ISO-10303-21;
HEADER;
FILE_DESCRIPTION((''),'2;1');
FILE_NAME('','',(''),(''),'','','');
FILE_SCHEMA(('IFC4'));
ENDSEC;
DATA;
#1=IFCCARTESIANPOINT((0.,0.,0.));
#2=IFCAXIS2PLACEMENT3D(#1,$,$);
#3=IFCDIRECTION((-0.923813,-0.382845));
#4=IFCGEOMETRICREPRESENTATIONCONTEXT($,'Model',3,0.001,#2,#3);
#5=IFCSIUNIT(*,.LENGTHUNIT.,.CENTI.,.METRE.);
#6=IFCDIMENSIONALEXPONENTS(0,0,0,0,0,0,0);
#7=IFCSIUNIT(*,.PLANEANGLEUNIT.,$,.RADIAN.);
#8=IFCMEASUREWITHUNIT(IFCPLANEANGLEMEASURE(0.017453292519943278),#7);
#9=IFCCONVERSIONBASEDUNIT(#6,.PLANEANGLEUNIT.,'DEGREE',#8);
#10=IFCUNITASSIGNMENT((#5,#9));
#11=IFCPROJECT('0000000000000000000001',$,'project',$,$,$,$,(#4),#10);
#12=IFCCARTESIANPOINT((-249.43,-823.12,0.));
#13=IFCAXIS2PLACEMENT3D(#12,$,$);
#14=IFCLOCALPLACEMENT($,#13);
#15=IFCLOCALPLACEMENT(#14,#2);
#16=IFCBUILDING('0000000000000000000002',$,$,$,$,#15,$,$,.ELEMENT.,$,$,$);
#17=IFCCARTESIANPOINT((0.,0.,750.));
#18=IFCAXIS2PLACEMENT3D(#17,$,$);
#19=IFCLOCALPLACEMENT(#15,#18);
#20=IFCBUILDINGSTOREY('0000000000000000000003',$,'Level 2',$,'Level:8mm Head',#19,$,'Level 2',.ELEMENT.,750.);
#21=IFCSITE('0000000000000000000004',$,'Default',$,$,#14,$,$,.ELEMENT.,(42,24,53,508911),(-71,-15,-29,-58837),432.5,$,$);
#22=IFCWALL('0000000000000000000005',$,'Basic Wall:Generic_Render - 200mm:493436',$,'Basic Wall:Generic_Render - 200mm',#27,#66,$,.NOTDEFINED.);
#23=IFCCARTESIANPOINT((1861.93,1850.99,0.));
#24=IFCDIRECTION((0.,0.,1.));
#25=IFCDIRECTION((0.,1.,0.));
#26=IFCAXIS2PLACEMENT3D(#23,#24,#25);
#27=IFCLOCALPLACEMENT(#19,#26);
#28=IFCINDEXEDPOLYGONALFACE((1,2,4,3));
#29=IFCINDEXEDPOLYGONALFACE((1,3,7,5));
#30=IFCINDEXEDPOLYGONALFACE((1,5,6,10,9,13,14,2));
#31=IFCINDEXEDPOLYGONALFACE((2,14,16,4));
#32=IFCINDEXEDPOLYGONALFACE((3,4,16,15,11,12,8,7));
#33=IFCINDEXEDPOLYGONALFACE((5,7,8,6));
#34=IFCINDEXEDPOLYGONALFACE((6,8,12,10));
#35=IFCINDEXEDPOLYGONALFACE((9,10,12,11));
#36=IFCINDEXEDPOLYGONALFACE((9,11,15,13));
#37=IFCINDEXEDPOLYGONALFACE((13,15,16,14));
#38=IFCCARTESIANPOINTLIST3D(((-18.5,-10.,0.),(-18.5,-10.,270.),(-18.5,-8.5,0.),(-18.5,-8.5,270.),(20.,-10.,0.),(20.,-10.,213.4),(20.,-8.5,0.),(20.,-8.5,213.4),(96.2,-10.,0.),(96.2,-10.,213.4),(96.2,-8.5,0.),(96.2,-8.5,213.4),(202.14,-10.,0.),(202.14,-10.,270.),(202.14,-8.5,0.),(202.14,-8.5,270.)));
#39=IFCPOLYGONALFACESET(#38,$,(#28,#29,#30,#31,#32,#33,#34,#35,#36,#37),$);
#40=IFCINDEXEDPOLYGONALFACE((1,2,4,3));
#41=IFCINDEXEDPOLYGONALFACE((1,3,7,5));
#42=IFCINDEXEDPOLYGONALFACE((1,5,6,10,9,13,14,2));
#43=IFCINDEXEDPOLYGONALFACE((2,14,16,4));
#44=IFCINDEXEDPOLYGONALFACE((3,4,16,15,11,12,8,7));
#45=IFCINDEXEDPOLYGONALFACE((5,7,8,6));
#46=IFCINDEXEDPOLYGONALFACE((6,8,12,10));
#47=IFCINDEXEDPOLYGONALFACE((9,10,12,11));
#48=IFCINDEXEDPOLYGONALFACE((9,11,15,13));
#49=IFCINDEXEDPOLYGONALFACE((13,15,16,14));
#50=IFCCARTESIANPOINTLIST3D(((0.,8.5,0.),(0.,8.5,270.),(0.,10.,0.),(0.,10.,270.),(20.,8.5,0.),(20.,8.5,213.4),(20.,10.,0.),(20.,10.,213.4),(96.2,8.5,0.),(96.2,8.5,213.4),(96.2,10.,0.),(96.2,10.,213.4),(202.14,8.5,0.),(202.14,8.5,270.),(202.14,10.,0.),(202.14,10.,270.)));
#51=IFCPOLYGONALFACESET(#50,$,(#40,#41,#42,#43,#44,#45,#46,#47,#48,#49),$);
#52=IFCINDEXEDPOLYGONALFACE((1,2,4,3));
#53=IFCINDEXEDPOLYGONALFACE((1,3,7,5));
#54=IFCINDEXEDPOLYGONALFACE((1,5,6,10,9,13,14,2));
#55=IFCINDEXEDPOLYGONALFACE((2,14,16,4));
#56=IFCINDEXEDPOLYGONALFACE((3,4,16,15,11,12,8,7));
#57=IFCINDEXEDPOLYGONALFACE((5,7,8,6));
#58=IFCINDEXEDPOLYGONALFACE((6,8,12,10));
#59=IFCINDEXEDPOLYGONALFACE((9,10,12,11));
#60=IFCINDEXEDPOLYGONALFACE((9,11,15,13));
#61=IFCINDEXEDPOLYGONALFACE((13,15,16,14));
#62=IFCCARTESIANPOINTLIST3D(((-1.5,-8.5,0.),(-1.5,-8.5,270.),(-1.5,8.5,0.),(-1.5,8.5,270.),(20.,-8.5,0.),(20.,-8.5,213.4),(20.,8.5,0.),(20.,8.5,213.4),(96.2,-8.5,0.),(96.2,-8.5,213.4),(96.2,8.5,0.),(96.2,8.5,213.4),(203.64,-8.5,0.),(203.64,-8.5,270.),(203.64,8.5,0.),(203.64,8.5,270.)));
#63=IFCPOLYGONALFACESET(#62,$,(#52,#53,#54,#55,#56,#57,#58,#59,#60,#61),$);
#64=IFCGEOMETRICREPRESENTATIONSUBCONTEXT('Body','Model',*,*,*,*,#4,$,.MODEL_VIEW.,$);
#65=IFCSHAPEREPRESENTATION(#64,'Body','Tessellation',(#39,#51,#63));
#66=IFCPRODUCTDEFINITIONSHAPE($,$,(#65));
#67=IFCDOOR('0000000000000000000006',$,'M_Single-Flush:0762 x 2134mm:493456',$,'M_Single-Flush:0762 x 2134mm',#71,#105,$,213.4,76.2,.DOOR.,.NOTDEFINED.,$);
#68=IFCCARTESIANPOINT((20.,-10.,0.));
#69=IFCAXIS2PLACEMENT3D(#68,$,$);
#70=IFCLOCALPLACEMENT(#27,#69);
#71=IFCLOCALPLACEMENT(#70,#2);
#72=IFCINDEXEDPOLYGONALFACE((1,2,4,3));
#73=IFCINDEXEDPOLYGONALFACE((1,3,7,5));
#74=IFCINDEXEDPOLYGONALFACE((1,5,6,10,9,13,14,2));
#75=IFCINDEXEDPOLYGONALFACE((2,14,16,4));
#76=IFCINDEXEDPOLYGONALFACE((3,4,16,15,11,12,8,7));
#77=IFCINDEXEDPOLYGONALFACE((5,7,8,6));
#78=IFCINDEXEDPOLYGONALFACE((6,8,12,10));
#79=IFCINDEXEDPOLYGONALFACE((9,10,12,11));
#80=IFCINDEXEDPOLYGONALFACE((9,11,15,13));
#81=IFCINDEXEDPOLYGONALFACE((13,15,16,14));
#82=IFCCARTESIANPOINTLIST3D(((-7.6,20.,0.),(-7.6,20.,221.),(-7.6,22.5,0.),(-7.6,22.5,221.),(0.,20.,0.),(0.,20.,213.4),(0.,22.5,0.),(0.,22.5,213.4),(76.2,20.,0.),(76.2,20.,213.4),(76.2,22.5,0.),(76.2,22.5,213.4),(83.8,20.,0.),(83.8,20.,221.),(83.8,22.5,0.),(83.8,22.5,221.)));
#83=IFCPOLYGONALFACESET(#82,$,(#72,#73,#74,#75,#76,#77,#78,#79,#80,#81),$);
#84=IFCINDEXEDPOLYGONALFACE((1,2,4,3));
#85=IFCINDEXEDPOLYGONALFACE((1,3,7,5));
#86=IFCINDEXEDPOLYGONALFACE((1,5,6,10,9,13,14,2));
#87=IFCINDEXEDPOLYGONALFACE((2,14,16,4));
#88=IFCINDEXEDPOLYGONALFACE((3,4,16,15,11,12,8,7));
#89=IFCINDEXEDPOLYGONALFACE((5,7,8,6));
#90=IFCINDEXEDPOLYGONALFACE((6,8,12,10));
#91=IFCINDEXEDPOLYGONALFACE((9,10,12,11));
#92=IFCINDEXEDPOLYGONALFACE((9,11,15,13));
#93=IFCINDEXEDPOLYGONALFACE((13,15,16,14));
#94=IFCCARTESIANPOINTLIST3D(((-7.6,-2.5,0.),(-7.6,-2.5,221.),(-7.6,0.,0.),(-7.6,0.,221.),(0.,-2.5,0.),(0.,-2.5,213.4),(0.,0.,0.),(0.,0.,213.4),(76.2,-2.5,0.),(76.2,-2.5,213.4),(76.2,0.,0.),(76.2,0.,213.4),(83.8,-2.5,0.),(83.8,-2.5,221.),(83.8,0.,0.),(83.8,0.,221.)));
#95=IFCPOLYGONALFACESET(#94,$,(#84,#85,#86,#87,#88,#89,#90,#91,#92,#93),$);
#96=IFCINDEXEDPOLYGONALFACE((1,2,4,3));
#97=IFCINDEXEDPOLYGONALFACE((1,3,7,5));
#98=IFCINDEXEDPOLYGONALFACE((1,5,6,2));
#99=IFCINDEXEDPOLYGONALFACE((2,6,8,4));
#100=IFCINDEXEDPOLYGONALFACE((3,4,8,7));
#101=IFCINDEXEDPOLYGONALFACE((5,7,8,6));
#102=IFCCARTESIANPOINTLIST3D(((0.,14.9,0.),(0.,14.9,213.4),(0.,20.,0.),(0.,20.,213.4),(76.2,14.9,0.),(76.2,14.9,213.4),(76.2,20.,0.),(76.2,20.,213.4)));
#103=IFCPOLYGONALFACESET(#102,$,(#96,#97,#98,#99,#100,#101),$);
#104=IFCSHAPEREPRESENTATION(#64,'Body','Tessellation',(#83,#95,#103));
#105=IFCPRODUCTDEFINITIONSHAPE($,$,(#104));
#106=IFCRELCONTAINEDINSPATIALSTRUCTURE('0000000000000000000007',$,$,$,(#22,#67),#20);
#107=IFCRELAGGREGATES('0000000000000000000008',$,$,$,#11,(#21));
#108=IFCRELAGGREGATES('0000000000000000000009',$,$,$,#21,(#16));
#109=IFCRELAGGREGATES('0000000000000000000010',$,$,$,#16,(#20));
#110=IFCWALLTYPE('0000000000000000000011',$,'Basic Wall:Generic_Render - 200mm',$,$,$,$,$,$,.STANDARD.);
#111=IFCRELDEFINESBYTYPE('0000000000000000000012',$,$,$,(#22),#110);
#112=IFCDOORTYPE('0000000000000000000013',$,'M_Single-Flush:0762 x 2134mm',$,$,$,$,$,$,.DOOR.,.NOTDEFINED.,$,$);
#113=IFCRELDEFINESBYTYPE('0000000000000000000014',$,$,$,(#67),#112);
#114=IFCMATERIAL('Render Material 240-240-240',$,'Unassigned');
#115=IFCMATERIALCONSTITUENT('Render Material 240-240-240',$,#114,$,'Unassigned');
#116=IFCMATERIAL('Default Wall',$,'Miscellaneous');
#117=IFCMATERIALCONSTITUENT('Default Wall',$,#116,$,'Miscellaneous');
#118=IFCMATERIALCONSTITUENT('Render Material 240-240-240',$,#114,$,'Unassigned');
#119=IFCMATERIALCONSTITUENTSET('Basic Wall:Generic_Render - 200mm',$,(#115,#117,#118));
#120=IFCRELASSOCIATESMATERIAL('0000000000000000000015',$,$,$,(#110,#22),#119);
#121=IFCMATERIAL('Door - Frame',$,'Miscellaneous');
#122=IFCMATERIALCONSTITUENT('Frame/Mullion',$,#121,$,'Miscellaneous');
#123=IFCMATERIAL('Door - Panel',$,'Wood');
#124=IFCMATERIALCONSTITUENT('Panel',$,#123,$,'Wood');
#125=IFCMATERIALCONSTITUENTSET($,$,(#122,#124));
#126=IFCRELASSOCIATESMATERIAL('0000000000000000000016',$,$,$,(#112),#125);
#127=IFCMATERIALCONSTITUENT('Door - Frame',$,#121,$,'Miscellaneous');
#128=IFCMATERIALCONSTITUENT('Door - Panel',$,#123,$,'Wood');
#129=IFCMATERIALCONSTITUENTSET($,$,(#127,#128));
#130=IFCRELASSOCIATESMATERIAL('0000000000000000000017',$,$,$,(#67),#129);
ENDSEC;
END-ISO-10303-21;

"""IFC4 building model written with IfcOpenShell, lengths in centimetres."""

from ifc_helpers import new_model, entity, si_unit, converted_unit, direction, frame, origin, place, context, subcontext, project, spatial, indexed_curve, outline, extrude, source, transform, mapped, material, constituent, constituent_set, type_object, type_shapes, element, fill, save


model = new_model("IFC4")

# Units and contexts
model_context = context("Model", 3, precision=0.001, world=origin(), true_north=direction((-0.923813, -0.382845)))
body_context = subcontext(model_context, "Body", "Model", "MODEL_VIEW")
ifc_project = project(units=[si_unit("LENGTHUNIT", "METRE", prefix="CENTI"), converted_unit("PLANEANGLEUNIT", "DEGREE", entity("IfcPlaneAngleMeasure", 0.017453292519943278), si_unit("PLANEANGLEUNIT", "RADIAN"), dimensions=[0, 0, 0, 0, 0, 0, 0])], contexts=[model_context])

# Site, building, storey
site_placement = place(None, frame((-249.43, -823.12, 0.0)))
site = spatial("IfcSite", under=ifc_project, at=site_placement, Name="Default", CompositionType="ELEMENT", RefLatitude=(42, 24, 53, 508911), RefLongitude=(-71, -15, -29, -58837), RefElevation=432.5)
building_placement = place(site_placement, origin())
building = spatial("IfcBuilding", under=site, at=building_placement, CompositionType="ELEMENT")
storey_placement = place(building_placement, frame((0.0, 0.0, 750.0)))
storey = spatial("IfcBuildingStorey", under=building, at=storey_placement, Name="Level 2", ObjectType="Level:8mm Head", LongName="Level 2", CompositionType="ELEMENT", Elevation=750.0)

# Shared definitions
ifc_material_1 = material(Name="Render Material 240-240-240", Category="Unassigned")
ifc_material_2 = material(Name="Default Wall", Category="Miscellaneous")
ifc_constituent_1 = constituent(ifc_material_1, Name="Render Material 240-240-240", Category="Unassigned")
ifc_constituent_2 = constituent(ifc_material_2, Name="Default Wall", Category="Miscellaneous")
ifc_constituent_3 = constituent(ifc_material_1, Name="Render Material 240-240-240", Category="Unassigned")
ifc_constituent_set_1 = constituent_set(constituents=[ifc_constituent_1, ifc_constituent_2, ifc_constituent_3], Name="Basic Wall:Generic_Render - 200mm")
wall_type_1 = type_object("IfcWallType", Name="Basic Wall:Generic_Render - 200mm", PredefinedType="STANDARD", material=ifc_constituent_set_1)

# Shared definitions
ifc_material_3 = material(Name="Door - Frame", Category="Miscellaneous")
ifc_material_4 = material(Name="Door - Panel", Category="Wood")

# Wall, opening, door
wall_1_placement = place(storey_placement, frame((1861.93, 1850.99, 0.0), z_axis=(0.0, 0.0, 1.0), x_axis=(0.0, 1.0, 0.0)))
wall_1 = element("IfcWall", 1, at=wall_1_placement, inside=storey, type_object=wall_type_1, material=ifc_constituent_set_1, Name="Basic Wall:Generic_Render - 200mm:493436", ObjectType="Basic Wall:Generic_Render - 200mm", PredefinedType="NOTDEFINED", context=body_context, shape_type="SweptSolid", body=[
    extrude(outline(indexed_curve([(-120.85, -127.18), (149.15, -127.18), (149.15, 93.46), (-120.85, 93.46), (-120.85, 54.96), (92.55, 54.96), (92.55, -21.24), (-120.85, -21.24), (-120.85, -127.18)], self_intersect=False)), frame((74.96, -8.5, 120.85), z_axis=(0.0, -1.0, 0.0), x_axis=(0.0, 0.0, 1.0)), (0.0, 0.0, 1.0), 1.5),
    extrude(outline(indexed_curve([(-59.58, -92.55), (-59.58, 120.85), (-79.58, 120.85), (-79.58, -149.15), (122.55, -149.15), (122.55, 120.85), (16.62, 120.85), (16.62, -92.55), (-59.58, -92.55)], self_intersect=False)), frame((79.58, 10.0, 120.85), z_axis=(0.0, 1.0, 0.0), x_axis=(1.0, 0.0, 0.0)), (0.0, 0.0, -1.0), 1.5),
    extrude(outline(indexed_curve([(-120.85, -124.05), (149.15, -124.05), (149.15, 81.08), (-120.85, 81.08), (-120.85, 59.58), (92.55, 59.58), (92.55, -16.62), (-120.85, -16.62), (-120.85, -124.05)], self_intersect=False)), frame((79.58, 8.5, 120.85), z_axis=(0.0, -1.0, 0.0), x_axis=(0.0, 0.0, 1.0)), (0.0, 0.0, 1.0), 17.0),
])
opening_1_placement = place(wall_1_placement, frame((20.0, -10.0, 0.0)))
opening_1 = element("IfcOpeningElement", 2, at=opening_1_placement, cuts=wall_1, PredefinedType="OPENING", context=body_context, shape_type="SweptSolid", body=[
    extrude(outline(indexed_curve([(0.0, 76.2), (0.0, 0.0), (213.4, 0.0), (213.4, 76.2), (0.0, 76.2)], self_intersect=False)), frame((0.0, 0.0, 0.0), z_axis=(0.0, 1.0, 0.0), x_axis=(0.0, 0.0, 1.0)), (0.0, 0.0, 1.0), 20.0),
])
ifc_constituent_4 = constituent(ifc_material_3, Name="Door - Frame", Category="Miscellaneous")
ifc_constituent_5 = constituent(ifc_material_4, Name="Door - Panel", Category="Wood")
ifc_constituent_set_2 = constituent_set(constituents=[ifc_constituent_4, ifc_constituent_5])
ifc_constituent_6 = constituent(ifc_material_3, Name="Frame/Mullion", Category="Miscellaneous")
ifc_constituent_7 = constituent(ifc_material_4, Name="Panel", Category="Wood")
ifc_constituent_set_3 = constituent_set(constituents=[ifc_constituent_6, ifc_constituent_7])
door_type_1 = type_object("IfcDoorType", Name="M_Single-Flush:0762 x 2134mm", OperationType="NOTDEFINED", PredefinedType="DOOR", material=ifc_constituent_set_3)
shared_shape_1 = source(origin(), body_context, "Body", "SweptSolid", [
    extrude(outline(indexed_curve([(-45.7, -112.4), (45.7, -112.4), (45.7, 108.6), (38.1, 108.6), (38.1, -104.8), (-38.1, -104.8), (-38.1, 108.6), (-45.7, 108.6), (-45.7, -112.4)], self_intersect=False)), frame((38.1, 22.5, 108.6), z_axis=(0.0, -1.0, 0.0), x_axis=(-1.0, 0.0, 0.0)), (0.0, 0.0, 1.0), 2.5),
    extrude(outline(indexed_curve([(-112.4, -45.7), (108.6, -45.7), (108.6, -38.1), (-104.8, -38.1), (-104.8, 38.1), (108.6, 38.1), (108.6, 45.7), (-112.4, 45.7), (-112.4, -45.7)], self_intersect=False)), frame((38.1, 0.0, 108.6), z_axis=(0.0, -1.0, 0.0), x_axis=(0.0, 0.0, -1.0)), (0.0, 0.0, 1.0), 2.5),
    extrude(outline(indexed_curve([(-38.1, -2.55), (38.1, -2.55), (38.1, 2.55), (-38.1, 2.55), (-38.1, -2.55)], self_intersect=False)), frame((38.1, 17.45, 0.0)), (0.0, 0.0, 1.0), 213.4),
])
type_shapes(door_type_1, [shared_shape_1])
door_1_placement = place(opening_1_placement, origin())
door_1 = element("IfcDoor", 3, at=door_1_placement, inside=storey, type_object=door_type_1, material=ifc_constituent_set_2, Name="M_Single-Flush:0762 x 2134mm:493456", ObjectType="M_Single-Flush:0762 x 2134mm", OperationType="NOTDEFINED", OverallHeight=213.4, OverallWidth=76.2, PredefinedType="DOOR", context=body_context, shape_type="MappedRepresentation", body=[
    mapped(shared_shape_1, transform((0.0, 0.0, 0.0), scale=1.0)),
])
fill(opening_1, door_1)

save(model, "model.ifc")
